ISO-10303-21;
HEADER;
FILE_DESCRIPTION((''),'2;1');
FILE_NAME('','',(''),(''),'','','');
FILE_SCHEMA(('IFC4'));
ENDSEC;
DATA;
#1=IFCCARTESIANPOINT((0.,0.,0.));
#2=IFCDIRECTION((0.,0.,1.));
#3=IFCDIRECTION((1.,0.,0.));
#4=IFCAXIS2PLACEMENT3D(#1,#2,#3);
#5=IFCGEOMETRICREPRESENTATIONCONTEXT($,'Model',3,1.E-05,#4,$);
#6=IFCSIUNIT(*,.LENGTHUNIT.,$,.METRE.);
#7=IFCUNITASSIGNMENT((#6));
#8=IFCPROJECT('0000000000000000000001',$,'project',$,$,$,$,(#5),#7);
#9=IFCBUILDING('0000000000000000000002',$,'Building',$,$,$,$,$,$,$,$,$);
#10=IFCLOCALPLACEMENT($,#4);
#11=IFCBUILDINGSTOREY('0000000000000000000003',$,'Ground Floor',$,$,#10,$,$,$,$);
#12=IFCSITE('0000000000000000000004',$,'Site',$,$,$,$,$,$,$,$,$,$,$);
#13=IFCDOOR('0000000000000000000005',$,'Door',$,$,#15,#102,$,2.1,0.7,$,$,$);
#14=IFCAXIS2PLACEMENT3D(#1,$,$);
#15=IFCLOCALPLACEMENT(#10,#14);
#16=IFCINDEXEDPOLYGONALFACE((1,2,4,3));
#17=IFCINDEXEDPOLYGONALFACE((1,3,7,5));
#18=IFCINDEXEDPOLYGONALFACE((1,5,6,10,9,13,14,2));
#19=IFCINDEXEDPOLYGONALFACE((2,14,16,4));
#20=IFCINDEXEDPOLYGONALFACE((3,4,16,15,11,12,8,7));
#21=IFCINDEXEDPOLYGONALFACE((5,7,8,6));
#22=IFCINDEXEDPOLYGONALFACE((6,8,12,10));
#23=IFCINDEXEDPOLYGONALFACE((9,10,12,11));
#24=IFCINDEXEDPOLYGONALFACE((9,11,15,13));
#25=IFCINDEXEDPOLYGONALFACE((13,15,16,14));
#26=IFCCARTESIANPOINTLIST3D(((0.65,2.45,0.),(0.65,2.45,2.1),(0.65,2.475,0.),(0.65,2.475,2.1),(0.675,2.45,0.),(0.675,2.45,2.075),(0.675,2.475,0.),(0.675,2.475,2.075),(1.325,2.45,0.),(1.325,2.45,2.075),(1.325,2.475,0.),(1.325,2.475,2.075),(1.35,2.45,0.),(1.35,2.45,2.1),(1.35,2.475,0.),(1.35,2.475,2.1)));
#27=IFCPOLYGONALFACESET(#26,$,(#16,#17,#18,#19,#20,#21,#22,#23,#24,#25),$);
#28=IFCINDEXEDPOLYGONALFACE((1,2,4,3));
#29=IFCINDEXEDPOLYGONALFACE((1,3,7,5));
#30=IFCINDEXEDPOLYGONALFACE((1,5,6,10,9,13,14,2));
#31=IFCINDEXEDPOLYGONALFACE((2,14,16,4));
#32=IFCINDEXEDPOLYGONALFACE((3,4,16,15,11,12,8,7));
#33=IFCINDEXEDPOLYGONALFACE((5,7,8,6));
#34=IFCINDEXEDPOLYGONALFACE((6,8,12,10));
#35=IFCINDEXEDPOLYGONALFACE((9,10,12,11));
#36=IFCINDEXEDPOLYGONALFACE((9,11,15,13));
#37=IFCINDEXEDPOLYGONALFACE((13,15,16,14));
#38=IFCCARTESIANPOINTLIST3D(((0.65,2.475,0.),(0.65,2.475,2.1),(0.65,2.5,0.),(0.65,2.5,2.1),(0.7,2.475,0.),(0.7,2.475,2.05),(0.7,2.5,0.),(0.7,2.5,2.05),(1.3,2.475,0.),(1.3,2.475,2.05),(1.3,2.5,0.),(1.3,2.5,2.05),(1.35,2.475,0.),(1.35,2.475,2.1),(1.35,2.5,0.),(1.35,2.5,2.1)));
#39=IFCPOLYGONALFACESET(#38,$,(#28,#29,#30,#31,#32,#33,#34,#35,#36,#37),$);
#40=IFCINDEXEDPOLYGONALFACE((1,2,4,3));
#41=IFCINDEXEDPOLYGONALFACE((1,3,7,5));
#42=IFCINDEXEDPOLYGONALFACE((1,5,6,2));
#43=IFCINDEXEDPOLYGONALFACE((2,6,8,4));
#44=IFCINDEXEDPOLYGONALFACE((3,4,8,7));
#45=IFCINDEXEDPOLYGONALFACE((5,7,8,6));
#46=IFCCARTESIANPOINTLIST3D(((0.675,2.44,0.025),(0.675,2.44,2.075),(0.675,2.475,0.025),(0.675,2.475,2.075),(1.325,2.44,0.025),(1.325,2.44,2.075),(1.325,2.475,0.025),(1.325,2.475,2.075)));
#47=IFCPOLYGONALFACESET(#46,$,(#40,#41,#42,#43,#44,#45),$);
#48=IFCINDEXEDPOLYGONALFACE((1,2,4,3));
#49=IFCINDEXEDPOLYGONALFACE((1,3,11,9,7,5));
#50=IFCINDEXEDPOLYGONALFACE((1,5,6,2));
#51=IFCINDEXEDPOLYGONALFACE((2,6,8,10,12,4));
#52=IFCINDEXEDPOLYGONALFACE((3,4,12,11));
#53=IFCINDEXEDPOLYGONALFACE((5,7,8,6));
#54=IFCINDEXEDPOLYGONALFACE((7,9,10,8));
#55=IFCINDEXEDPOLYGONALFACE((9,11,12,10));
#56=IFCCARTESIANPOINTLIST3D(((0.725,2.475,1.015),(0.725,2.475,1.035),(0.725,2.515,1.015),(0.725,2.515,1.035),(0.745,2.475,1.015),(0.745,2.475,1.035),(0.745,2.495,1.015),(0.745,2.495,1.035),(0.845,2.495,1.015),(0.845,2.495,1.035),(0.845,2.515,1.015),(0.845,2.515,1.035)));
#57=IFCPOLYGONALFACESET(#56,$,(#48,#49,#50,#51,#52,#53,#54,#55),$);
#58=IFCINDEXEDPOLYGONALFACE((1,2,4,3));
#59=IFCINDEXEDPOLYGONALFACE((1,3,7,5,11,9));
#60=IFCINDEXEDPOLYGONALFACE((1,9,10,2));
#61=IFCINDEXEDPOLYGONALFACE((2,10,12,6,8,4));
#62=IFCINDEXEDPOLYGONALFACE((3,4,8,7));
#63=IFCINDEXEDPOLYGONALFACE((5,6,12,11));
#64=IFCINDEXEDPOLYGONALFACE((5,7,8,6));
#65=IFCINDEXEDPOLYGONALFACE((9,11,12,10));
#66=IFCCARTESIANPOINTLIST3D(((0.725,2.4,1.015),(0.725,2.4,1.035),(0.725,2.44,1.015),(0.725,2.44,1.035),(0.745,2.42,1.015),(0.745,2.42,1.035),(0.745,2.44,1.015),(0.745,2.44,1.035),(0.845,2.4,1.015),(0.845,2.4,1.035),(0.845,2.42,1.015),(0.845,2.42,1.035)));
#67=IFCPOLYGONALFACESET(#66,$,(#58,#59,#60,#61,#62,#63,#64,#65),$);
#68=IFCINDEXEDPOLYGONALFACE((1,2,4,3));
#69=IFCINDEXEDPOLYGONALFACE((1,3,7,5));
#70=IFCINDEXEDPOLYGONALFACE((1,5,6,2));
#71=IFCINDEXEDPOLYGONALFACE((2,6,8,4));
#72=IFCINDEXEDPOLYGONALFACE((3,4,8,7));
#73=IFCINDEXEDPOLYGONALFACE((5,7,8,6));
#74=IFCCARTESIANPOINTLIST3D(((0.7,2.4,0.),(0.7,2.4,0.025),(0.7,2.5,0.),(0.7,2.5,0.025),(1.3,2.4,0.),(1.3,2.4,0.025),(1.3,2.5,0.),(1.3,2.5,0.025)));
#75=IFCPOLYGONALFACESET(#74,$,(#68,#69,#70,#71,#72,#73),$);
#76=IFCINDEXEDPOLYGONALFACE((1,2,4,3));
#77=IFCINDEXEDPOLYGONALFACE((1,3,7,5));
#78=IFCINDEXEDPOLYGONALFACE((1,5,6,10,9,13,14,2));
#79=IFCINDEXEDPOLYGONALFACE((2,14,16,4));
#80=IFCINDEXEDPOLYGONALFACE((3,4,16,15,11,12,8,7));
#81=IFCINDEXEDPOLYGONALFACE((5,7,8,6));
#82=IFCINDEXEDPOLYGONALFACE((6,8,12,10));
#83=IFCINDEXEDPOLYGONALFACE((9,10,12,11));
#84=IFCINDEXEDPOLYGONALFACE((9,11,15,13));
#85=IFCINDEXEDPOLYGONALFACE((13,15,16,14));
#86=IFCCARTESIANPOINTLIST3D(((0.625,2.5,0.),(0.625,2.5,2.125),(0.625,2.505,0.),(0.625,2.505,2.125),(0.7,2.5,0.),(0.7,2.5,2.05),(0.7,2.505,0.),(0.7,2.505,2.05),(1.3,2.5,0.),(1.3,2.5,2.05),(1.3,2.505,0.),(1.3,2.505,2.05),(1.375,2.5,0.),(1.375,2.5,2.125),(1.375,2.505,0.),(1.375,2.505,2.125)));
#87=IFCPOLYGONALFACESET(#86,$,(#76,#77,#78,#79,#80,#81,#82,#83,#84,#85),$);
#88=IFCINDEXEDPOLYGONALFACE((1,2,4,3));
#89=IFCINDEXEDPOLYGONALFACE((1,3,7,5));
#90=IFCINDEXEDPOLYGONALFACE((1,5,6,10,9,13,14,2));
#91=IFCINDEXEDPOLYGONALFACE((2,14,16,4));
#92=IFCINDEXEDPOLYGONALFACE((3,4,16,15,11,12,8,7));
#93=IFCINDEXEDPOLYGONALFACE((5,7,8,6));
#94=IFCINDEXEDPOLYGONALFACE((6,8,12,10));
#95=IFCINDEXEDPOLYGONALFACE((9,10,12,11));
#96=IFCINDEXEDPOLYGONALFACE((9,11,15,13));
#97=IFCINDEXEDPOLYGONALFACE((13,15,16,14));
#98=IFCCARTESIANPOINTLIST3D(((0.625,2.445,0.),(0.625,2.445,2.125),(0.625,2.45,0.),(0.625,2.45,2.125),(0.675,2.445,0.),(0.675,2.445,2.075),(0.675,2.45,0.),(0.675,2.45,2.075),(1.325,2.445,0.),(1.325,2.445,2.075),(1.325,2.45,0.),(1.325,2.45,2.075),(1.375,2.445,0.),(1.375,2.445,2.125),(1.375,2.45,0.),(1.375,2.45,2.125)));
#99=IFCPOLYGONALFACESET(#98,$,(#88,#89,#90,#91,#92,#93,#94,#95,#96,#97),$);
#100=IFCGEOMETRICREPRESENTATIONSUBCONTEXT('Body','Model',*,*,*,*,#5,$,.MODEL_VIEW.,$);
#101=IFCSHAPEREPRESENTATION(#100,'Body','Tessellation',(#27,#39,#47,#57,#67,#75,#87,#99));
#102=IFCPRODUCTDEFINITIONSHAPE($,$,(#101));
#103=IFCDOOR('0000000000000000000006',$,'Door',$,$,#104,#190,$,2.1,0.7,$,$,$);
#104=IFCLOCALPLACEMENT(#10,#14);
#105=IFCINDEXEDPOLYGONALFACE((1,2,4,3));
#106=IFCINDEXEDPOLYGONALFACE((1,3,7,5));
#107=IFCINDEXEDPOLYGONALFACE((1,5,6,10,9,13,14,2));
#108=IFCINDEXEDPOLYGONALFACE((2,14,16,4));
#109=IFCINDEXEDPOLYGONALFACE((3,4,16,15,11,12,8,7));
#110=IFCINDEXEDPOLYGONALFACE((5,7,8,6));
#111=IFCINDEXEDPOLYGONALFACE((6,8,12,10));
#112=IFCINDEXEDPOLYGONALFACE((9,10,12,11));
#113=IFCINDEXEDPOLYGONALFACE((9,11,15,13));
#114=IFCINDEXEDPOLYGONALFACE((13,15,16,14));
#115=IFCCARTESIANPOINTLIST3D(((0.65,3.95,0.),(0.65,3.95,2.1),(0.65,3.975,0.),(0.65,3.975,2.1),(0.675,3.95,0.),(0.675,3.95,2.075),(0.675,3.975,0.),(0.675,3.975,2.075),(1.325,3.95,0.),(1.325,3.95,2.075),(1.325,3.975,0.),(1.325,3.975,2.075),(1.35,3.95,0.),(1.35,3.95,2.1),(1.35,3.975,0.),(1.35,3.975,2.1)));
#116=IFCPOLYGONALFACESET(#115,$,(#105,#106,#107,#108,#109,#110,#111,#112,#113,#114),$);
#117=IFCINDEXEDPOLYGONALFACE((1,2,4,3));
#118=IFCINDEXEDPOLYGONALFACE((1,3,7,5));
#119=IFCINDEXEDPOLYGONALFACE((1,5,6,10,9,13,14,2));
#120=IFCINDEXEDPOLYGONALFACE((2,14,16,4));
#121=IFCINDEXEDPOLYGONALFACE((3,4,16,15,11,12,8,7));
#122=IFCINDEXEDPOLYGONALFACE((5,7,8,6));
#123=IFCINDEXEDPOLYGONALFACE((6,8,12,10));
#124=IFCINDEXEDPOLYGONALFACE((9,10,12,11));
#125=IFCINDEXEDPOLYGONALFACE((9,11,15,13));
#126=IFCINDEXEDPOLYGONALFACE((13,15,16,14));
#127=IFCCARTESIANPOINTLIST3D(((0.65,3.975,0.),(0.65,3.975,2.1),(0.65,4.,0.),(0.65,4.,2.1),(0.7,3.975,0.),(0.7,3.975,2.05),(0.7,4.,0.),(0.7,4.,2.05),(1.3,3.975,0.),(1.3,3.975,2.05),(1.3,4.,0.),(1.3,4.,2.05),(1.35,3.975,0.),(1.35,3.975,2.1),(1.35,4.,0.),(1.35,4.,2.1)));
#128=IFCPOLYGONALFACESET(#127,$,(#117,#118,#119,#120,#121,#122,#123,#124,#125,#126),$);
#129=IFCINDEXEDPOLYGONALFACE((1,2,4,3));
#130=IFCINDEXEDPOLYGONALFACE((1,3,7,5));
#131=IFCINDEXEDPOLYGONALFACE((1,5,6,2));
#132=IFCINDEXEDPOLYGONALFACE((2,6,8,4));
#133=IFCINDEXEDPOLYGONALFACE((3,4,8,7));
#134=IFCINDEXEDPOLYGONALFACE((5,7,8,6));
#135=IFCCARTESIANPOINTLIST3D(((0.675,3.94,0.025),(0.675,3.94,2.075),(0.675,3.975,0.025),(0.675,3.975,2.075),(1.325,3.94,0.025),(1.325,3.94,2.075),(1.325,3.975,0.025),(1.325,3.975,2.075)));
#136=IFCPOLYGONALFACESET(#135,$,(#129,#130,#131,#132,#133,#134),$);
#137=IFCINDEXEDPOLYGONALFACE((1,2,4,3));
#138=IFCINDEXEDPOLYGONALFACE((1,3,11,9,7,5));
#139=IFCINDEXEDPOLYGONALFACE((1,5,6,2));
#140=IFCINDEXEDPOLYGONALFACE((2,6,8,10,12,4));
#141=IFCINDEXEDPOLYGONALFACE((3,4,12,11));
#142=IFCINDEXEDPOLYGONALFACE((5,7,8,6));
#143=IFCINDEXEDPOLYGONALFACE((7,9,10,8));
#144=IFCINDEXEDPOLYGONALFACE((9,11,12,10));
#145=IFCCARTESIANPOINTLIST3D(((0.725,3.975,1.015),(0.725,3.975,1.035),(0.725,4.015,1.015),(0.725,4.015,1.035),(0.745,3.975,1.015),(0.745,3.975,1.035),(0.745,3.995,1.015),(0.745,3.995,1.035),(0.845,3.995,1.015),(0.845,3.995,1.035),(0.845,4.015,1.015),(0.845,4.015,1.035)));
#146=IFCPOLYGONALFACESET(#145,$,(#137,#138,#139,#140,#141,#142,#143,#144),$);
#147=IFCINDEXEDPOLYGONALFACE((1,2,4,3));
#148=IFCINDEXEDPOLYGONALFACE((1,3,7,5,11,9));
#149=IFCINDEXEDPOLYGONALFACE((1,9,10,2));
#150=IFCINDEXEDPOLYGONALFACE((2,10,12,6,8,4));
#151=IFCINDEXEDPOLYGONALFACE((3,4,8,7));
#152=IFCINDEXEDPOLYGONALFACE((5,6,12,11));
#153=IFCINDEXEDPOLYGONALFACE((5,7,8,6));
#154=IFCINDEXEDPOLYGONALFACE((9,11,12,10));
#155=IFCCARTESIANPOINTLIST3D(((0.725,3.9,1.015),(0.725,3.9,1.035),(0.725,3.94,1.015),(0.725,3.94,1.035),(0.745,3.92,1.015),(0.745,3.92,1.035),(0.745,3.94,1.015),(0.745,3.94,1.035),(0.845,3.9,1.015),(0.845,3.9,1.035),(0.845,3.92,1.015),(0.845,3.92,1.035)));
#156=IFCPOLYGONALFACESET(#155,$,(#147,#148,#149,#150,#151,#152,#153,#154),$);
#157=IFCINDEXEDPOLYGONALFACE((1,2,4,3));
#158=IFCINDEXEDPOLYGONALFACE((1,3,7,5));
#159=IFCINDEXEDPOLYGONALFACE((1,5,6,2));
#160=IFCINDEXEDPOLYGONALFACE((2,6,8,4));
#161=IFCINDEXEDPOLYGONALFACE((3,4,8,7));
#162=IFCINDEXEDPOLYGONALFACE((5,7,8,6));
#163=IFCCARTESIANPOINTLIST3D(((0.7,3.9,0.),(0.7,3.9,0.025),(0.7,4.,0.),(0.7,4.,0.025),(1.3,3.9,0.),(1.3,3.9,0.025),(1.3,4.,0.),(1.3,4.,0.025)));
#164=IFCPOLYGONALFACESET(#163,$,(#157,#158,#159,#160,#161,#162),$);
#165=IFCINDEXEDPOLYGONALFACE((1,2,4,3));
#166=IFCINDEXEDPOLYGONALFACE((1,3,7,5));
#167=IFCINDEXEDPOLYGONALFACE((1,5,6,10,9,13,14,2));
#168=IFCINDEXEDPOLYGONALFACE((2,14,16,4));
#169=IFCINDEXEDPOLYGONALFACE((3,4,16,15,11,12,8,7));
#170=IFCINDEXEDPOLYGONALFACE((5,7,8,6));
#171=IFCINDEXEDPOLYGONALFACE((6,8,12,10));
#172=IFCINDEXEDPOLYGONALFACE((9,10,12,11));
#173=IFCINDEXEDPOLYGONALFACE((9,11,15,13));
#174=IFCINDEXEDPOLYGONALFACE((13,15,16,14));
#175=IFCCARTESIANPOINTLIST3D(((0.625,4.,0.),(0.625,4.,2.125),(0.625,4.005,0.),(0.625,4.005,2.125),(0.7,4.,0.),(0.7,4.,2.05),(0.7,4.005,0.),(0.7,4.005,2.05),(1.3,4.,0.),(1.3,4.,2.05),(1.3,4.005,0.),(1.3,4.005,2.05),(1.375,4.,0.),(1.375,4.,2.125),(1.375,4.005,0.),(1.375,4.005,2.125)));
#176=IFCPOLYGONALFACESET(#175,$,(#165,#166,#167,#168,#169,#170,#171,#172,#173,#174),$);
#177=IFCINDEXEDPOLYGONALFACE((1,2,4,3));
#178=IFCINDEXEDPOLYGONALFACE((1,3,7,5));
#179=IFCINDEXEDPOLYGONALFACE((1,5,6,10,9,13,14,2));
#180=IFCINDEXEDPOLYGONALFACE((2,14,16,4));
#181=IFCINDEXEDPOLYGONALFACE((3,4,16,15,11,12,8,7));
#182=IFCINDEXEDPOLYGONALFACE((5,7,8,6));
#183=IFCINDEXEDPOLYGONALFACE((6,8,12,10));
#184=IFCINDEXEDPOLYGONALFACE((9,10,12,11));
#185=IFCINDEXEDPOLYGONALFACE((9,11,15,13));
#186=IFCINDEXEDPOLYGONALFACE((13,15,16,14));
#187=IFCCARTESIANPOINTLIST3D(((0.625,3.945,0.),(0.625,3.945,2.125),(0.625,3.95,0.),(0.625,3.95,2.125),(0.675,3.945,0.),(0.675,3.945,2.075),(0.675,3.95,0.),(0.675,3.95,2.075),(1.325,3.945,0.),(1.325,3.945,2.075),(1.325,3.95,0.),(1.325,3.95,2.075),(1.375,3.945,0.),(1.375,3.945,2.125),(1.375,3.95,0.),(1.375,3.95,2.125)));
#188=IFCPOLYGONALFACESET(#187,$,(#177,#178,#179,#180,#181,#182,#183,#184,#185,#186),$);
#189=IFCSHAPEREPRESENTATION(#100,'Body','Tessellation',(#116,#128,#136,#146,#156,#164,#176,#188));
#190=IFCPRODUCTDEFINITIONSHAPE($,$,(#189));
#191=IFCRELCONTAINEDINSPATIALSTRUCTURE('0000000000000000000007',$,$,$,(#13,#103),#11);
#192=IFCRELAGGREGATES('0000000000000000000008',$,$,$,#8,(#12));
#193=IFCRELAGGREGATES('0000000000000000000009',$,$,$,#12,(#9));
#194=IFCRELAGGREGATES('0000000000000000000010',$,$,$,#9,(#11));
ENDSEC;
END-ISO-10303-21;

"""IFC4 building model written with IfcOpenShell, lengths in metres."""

from ifc_helpers import new_model, si_unit, frame, origin_with_axes, place, context, subcontext, project, spatial, line, indexed_curve, outline, extrude, element, save


model = new_model("IFC4")

# Units and contexts
model_context = context("Model", 3, precision=1e-05, world=origin_with_axes())
body_context = subcontext(model_context, "Body", "Model", "MODEL_VIEW")
ifc_project = project(units=[si_unit("LENGTHUNIT", "METRE")], contexts=[model_context])

# Site, building, storey
site = spatial("IfcSite", under=ifc_project, Name="Site")
building = spatial("IfcBuilding", under=site, Name="Building")
storey_placement = place(None, origin_with_axes())
storey = spatial("IfcBuildingStorey", under=building, at=storey_placement, Name="Ground Floor")

# Doors
door_1_placement = place(storey_placement, frame((1.35, 2.5, 0.0), z_axis=(0.0, 0.0, 1.0), x_axis=(-1.0, 0.0, 0.0)))
element("IfcDoor", 1, at=door_1_placement, inside=storey, Name="Door", OverallHeight=2.1, OverallWidth=0.7, context=body_context, shape_type="SweptSolid", body=[
    extrude(outline(indexed_curve([(0.0, 0.0), (0.0, 2.1), (0.7, 2.1), (0.7, 0.0), (0.675, 0.0), (0.675, 2.075), (0.025, 2.075), (0.025, 0.0)], segments=[line(1, 2, 3, 4, 5, 6, 7, 8, 1)])), frame((0.0, 0.025, 0.0), z_axis=(0.0, -1.0, 0.0), x_axis=(1.0, 0.0, 0.0)), (0.0, 0.0, -1.0), 0.025),
    extrude(outline(indexed_curve([(0.0, 0.0), (0.0, 2.1), (0.7, 2.1), (0.7, 0.0), (0.65, 0.0), (0.65, 2.05), (0.05, 2.05), (0.05, 0.0)], segments=[line(1, 2, 3, 4, 5, 6, 7, 8, 1)])), frame((0.0, 0.0, 0.0), z_axis=(0.0, -1.0, 0.0), x_axis=(1.0, 0.0, 0.0)), (0.0, 0.0, -1.0), 0.025),
    extrude(outline(indexed_curve([(0.0, 0.0), (0.65, 0.0), (0.65, 0.035), (0.0, 0.035)], segments=[line(1, 2, 3, 4, 1)])), frame((0.025, 0.025, 0.025), z_axis=(0.0, 0.0, 1.0), x_axis=(1.0, 0.0, 0.0)), (0.0, 0.0, 1.0), 2.05),
    extrude(outline(indexed_curve([(0.0, 0.0), (0.0, -0.04), (-0.12, -0.04), (-0.12, -0.02), (-0.02, -0.02), (-0.02, 0.0)], segments=[line(1, 2, 3, 4, 5, 6, 1)])), frame((0.625, 0.025, 1.015), z_axis=(0.0, 0.0, 1.0), x_axis=(1.0, 0.0, 0.0)), (0.0, 0.0, 1.0), 0.02),
    extrude(outline(indexed_curve([(0.0, 0.0), (0.0, 0.04), (-0.12, 0.04), (-0.12, 0.02), (-0.02, 0.02), (-0.02, 0.0)], segments=[line(1, 2, 3, 4, 5, 6, 1)])), frame((0.625, 0.06, 1.015), z_axis=(0.0, 0.0, 1.0), x_axis=(1.0, 0.0, 0.0)), (0.0, 0.0, 1.0), 0.02),
    extrude(outline(indexed_curve([(0.0, 0.0), (0.6, 0.0), (0.6, 0.1), (0.0, 0.1)], segments=[line(1, 2, 3, 4, 1)])), frame((0.05, 0.0, 0.0), z_axis=(0.0, 0.0, 1.0), x_axis=(1.0, 0.0, 0.0)), (0.0, 0.0, 1.0), 0.025),
    extrude(outline(indexed_curve([(0.0, 0.0), (0.0, 2.125), (0.75, 2.125), (0.75, 0.0), (0.675, 0.0), (0.675, 2.05), (0.075, 2.05), (0.075, 0.0)], segments=[line(1, 2, 3, 4, 5, 6, 7, 8, 1)])), frame((-0.025, -0.005, 0.0), z_axis=(0.0, -1.0, 0.0), x_axis=(1.0, 0.0, 0.0)), (0.0, 0.0, -1.0), 0.005),
    extrude(outline(indexed_curve([(0.0, 0.0), (0.0, 2.125), (0.75, 2.125), (0.75, 0.0), (0.7, 0.0), (0.7, 2.075), (0.05, 2.075), (0.05, 0.0)], segments=[line(1, 2, 3, 4, 5, 6, 7, 8, 1)])), frame((-0.025, 0.05, 0.0), z_axis=(0.0, -1.0, 0.0), x_axis=(1.0, 0.0, 0.0)), (0.0, 0.0, -1.0), 0.005),
])
door_2_placement = place(storey_placement, frame((1.35, 4.0, 0.0), z_axis=(0.0, 0.0, 1.0), x_axis=(-1.0, 0.0, 0.0)))
element("IfcDoor", 2, at=door_2_placement, inside=storey, Name="Door", OverallHeight=2.1, OverallWidth=0.7, context=body_context, shape_type="SweptSolid", body=[
    extrude(outline(indexed_curve([(0.0, 0.0), (0.0, 2.1), (0.7, 2.1), (0.7, 0.0), (0.675, 0.0), (0.675, 2.075), (0.025, 2.075), (0.025, 0.0)], segments=[line(1, 2, 3, 4, 5, 6, 7, 8, 1)])), frame((0.0, 0.025, 0.0), z_axis=(0.0, -1.0, 0.0), x_axis=(1.0, 0.0, 0.0)), (0.0, 0.0, -1.0), 0.025),
    extrude(outline(indexed_curve([(0.0, 0.0), (0.0, 2.1), (0.7, 2.1), (0.7, 0.0), (0.65, 0.0), (0.65, 2.05), (0.05, 2.05), (0.05, 0.0)], segments=[line(1, 2, 3, 4, 5, 6, 7, 8, 1)])), frame((0.0, 0.0, 0.0), z_axis=(0.0, -1.0, 0.0), x_axis=(1.0, 0.0, 0.0)), (0.0, 0.0, -1.0), 0.025),
    extrude(outline(indexed_curve([(0.0, 0.0), (0.65, 0.0), (0.65, 0.035), (0.0, 0.035)], segments=[line(1, 2, 3, 4, 1)])), frame((0.025, 0.025, 0.025), z_axis=(0.0, 0.0, 1.0), x_axis=(1.0, 0.0, 0.0)), (0.0, 0.0, 1.0), 2.05),
    extrude(outline(indexed_curve([(0.0, 0.0), (0.0, -0.04), (-0.12, -0.04), (-0.12, -0.02), (-0.02, -0.02), (-0.02, 0.0)], segments=[line(1, 2, 3, 4, 5, 6, 1)])), frame((0.625, 0.025, 1.015), z_axis=(0.0, 0.0, 1.0), x_axis=(1.0, 0.0, 0.0)), (0.0, 0.0, 1.0), 0.02),
    extrude(outline(indexed_curve([(0.0, 0.0), (0.0, 0.04), (-0.12, 0.04), (-0.12, 0.02), (-0.02, 0.02), (-0.02, 0.0)], segments=[line(1, 2, 3, 4, 5, 6, 1)])), frame((0.625, 0.06, 1.015), z_axis=(0.0, 0.0, 1.0), x_axis=(1.0, 0.0, 0.0)), (0.0, 0.0, 1.0), 0.02),
    extrude(outline(indexed_curve([(0.0, 0.0), (0.6, 0.0), (0.6, 0.1), (0.0, 0.1)], segments=[line(1, 2, 3, 4, 1)])), frame((0.05, 0.0, 0.0), z_axis=(0.0, 0.0, 1.0), x_axis=(1.0, 0.0, 0.0)), (0.0, 0.0, 1.0), 0.025),
    extrude(outline(indexed_curve([(0.0, 0.0), (0.0, 2.125), (0.75, 2.125), (0.75, 0.0), (0.675, 0.0), (0.675, 2.05), (0.075, 2.05), (0.075, 0.0)], segments=[line(1, 2, 3, 4, 5, 6, 7, 8, 1)])), frame((-0.025, -0.005, 0.0), z_axis=(0.0, -1.0, 0.0), x_axis=(1.0, 0.0, 0.0)), (0.0, 0.0, -1.0), 0.005),
    extrude(outline(indexed_curve([(0.0, 0.0), (0.0, 2.125), (0.75, 2.125), (0.75, 0.0), (0.7, 0.0), (0.7, 2.075), (0.05, 2.075), (0.05, 0.0)], segments=[line(1, 2, 3, 4, 5, 6, 7, 8, 1)])), frame((-0.025, 0.05, 0.0), z_axis=(0.0, -1.0, 0.0), x_axis=(1.0, 0.0, 0.0)), (0.0, 0.0, -1.0), 0.005),
])

save(model, "model.ifc")
